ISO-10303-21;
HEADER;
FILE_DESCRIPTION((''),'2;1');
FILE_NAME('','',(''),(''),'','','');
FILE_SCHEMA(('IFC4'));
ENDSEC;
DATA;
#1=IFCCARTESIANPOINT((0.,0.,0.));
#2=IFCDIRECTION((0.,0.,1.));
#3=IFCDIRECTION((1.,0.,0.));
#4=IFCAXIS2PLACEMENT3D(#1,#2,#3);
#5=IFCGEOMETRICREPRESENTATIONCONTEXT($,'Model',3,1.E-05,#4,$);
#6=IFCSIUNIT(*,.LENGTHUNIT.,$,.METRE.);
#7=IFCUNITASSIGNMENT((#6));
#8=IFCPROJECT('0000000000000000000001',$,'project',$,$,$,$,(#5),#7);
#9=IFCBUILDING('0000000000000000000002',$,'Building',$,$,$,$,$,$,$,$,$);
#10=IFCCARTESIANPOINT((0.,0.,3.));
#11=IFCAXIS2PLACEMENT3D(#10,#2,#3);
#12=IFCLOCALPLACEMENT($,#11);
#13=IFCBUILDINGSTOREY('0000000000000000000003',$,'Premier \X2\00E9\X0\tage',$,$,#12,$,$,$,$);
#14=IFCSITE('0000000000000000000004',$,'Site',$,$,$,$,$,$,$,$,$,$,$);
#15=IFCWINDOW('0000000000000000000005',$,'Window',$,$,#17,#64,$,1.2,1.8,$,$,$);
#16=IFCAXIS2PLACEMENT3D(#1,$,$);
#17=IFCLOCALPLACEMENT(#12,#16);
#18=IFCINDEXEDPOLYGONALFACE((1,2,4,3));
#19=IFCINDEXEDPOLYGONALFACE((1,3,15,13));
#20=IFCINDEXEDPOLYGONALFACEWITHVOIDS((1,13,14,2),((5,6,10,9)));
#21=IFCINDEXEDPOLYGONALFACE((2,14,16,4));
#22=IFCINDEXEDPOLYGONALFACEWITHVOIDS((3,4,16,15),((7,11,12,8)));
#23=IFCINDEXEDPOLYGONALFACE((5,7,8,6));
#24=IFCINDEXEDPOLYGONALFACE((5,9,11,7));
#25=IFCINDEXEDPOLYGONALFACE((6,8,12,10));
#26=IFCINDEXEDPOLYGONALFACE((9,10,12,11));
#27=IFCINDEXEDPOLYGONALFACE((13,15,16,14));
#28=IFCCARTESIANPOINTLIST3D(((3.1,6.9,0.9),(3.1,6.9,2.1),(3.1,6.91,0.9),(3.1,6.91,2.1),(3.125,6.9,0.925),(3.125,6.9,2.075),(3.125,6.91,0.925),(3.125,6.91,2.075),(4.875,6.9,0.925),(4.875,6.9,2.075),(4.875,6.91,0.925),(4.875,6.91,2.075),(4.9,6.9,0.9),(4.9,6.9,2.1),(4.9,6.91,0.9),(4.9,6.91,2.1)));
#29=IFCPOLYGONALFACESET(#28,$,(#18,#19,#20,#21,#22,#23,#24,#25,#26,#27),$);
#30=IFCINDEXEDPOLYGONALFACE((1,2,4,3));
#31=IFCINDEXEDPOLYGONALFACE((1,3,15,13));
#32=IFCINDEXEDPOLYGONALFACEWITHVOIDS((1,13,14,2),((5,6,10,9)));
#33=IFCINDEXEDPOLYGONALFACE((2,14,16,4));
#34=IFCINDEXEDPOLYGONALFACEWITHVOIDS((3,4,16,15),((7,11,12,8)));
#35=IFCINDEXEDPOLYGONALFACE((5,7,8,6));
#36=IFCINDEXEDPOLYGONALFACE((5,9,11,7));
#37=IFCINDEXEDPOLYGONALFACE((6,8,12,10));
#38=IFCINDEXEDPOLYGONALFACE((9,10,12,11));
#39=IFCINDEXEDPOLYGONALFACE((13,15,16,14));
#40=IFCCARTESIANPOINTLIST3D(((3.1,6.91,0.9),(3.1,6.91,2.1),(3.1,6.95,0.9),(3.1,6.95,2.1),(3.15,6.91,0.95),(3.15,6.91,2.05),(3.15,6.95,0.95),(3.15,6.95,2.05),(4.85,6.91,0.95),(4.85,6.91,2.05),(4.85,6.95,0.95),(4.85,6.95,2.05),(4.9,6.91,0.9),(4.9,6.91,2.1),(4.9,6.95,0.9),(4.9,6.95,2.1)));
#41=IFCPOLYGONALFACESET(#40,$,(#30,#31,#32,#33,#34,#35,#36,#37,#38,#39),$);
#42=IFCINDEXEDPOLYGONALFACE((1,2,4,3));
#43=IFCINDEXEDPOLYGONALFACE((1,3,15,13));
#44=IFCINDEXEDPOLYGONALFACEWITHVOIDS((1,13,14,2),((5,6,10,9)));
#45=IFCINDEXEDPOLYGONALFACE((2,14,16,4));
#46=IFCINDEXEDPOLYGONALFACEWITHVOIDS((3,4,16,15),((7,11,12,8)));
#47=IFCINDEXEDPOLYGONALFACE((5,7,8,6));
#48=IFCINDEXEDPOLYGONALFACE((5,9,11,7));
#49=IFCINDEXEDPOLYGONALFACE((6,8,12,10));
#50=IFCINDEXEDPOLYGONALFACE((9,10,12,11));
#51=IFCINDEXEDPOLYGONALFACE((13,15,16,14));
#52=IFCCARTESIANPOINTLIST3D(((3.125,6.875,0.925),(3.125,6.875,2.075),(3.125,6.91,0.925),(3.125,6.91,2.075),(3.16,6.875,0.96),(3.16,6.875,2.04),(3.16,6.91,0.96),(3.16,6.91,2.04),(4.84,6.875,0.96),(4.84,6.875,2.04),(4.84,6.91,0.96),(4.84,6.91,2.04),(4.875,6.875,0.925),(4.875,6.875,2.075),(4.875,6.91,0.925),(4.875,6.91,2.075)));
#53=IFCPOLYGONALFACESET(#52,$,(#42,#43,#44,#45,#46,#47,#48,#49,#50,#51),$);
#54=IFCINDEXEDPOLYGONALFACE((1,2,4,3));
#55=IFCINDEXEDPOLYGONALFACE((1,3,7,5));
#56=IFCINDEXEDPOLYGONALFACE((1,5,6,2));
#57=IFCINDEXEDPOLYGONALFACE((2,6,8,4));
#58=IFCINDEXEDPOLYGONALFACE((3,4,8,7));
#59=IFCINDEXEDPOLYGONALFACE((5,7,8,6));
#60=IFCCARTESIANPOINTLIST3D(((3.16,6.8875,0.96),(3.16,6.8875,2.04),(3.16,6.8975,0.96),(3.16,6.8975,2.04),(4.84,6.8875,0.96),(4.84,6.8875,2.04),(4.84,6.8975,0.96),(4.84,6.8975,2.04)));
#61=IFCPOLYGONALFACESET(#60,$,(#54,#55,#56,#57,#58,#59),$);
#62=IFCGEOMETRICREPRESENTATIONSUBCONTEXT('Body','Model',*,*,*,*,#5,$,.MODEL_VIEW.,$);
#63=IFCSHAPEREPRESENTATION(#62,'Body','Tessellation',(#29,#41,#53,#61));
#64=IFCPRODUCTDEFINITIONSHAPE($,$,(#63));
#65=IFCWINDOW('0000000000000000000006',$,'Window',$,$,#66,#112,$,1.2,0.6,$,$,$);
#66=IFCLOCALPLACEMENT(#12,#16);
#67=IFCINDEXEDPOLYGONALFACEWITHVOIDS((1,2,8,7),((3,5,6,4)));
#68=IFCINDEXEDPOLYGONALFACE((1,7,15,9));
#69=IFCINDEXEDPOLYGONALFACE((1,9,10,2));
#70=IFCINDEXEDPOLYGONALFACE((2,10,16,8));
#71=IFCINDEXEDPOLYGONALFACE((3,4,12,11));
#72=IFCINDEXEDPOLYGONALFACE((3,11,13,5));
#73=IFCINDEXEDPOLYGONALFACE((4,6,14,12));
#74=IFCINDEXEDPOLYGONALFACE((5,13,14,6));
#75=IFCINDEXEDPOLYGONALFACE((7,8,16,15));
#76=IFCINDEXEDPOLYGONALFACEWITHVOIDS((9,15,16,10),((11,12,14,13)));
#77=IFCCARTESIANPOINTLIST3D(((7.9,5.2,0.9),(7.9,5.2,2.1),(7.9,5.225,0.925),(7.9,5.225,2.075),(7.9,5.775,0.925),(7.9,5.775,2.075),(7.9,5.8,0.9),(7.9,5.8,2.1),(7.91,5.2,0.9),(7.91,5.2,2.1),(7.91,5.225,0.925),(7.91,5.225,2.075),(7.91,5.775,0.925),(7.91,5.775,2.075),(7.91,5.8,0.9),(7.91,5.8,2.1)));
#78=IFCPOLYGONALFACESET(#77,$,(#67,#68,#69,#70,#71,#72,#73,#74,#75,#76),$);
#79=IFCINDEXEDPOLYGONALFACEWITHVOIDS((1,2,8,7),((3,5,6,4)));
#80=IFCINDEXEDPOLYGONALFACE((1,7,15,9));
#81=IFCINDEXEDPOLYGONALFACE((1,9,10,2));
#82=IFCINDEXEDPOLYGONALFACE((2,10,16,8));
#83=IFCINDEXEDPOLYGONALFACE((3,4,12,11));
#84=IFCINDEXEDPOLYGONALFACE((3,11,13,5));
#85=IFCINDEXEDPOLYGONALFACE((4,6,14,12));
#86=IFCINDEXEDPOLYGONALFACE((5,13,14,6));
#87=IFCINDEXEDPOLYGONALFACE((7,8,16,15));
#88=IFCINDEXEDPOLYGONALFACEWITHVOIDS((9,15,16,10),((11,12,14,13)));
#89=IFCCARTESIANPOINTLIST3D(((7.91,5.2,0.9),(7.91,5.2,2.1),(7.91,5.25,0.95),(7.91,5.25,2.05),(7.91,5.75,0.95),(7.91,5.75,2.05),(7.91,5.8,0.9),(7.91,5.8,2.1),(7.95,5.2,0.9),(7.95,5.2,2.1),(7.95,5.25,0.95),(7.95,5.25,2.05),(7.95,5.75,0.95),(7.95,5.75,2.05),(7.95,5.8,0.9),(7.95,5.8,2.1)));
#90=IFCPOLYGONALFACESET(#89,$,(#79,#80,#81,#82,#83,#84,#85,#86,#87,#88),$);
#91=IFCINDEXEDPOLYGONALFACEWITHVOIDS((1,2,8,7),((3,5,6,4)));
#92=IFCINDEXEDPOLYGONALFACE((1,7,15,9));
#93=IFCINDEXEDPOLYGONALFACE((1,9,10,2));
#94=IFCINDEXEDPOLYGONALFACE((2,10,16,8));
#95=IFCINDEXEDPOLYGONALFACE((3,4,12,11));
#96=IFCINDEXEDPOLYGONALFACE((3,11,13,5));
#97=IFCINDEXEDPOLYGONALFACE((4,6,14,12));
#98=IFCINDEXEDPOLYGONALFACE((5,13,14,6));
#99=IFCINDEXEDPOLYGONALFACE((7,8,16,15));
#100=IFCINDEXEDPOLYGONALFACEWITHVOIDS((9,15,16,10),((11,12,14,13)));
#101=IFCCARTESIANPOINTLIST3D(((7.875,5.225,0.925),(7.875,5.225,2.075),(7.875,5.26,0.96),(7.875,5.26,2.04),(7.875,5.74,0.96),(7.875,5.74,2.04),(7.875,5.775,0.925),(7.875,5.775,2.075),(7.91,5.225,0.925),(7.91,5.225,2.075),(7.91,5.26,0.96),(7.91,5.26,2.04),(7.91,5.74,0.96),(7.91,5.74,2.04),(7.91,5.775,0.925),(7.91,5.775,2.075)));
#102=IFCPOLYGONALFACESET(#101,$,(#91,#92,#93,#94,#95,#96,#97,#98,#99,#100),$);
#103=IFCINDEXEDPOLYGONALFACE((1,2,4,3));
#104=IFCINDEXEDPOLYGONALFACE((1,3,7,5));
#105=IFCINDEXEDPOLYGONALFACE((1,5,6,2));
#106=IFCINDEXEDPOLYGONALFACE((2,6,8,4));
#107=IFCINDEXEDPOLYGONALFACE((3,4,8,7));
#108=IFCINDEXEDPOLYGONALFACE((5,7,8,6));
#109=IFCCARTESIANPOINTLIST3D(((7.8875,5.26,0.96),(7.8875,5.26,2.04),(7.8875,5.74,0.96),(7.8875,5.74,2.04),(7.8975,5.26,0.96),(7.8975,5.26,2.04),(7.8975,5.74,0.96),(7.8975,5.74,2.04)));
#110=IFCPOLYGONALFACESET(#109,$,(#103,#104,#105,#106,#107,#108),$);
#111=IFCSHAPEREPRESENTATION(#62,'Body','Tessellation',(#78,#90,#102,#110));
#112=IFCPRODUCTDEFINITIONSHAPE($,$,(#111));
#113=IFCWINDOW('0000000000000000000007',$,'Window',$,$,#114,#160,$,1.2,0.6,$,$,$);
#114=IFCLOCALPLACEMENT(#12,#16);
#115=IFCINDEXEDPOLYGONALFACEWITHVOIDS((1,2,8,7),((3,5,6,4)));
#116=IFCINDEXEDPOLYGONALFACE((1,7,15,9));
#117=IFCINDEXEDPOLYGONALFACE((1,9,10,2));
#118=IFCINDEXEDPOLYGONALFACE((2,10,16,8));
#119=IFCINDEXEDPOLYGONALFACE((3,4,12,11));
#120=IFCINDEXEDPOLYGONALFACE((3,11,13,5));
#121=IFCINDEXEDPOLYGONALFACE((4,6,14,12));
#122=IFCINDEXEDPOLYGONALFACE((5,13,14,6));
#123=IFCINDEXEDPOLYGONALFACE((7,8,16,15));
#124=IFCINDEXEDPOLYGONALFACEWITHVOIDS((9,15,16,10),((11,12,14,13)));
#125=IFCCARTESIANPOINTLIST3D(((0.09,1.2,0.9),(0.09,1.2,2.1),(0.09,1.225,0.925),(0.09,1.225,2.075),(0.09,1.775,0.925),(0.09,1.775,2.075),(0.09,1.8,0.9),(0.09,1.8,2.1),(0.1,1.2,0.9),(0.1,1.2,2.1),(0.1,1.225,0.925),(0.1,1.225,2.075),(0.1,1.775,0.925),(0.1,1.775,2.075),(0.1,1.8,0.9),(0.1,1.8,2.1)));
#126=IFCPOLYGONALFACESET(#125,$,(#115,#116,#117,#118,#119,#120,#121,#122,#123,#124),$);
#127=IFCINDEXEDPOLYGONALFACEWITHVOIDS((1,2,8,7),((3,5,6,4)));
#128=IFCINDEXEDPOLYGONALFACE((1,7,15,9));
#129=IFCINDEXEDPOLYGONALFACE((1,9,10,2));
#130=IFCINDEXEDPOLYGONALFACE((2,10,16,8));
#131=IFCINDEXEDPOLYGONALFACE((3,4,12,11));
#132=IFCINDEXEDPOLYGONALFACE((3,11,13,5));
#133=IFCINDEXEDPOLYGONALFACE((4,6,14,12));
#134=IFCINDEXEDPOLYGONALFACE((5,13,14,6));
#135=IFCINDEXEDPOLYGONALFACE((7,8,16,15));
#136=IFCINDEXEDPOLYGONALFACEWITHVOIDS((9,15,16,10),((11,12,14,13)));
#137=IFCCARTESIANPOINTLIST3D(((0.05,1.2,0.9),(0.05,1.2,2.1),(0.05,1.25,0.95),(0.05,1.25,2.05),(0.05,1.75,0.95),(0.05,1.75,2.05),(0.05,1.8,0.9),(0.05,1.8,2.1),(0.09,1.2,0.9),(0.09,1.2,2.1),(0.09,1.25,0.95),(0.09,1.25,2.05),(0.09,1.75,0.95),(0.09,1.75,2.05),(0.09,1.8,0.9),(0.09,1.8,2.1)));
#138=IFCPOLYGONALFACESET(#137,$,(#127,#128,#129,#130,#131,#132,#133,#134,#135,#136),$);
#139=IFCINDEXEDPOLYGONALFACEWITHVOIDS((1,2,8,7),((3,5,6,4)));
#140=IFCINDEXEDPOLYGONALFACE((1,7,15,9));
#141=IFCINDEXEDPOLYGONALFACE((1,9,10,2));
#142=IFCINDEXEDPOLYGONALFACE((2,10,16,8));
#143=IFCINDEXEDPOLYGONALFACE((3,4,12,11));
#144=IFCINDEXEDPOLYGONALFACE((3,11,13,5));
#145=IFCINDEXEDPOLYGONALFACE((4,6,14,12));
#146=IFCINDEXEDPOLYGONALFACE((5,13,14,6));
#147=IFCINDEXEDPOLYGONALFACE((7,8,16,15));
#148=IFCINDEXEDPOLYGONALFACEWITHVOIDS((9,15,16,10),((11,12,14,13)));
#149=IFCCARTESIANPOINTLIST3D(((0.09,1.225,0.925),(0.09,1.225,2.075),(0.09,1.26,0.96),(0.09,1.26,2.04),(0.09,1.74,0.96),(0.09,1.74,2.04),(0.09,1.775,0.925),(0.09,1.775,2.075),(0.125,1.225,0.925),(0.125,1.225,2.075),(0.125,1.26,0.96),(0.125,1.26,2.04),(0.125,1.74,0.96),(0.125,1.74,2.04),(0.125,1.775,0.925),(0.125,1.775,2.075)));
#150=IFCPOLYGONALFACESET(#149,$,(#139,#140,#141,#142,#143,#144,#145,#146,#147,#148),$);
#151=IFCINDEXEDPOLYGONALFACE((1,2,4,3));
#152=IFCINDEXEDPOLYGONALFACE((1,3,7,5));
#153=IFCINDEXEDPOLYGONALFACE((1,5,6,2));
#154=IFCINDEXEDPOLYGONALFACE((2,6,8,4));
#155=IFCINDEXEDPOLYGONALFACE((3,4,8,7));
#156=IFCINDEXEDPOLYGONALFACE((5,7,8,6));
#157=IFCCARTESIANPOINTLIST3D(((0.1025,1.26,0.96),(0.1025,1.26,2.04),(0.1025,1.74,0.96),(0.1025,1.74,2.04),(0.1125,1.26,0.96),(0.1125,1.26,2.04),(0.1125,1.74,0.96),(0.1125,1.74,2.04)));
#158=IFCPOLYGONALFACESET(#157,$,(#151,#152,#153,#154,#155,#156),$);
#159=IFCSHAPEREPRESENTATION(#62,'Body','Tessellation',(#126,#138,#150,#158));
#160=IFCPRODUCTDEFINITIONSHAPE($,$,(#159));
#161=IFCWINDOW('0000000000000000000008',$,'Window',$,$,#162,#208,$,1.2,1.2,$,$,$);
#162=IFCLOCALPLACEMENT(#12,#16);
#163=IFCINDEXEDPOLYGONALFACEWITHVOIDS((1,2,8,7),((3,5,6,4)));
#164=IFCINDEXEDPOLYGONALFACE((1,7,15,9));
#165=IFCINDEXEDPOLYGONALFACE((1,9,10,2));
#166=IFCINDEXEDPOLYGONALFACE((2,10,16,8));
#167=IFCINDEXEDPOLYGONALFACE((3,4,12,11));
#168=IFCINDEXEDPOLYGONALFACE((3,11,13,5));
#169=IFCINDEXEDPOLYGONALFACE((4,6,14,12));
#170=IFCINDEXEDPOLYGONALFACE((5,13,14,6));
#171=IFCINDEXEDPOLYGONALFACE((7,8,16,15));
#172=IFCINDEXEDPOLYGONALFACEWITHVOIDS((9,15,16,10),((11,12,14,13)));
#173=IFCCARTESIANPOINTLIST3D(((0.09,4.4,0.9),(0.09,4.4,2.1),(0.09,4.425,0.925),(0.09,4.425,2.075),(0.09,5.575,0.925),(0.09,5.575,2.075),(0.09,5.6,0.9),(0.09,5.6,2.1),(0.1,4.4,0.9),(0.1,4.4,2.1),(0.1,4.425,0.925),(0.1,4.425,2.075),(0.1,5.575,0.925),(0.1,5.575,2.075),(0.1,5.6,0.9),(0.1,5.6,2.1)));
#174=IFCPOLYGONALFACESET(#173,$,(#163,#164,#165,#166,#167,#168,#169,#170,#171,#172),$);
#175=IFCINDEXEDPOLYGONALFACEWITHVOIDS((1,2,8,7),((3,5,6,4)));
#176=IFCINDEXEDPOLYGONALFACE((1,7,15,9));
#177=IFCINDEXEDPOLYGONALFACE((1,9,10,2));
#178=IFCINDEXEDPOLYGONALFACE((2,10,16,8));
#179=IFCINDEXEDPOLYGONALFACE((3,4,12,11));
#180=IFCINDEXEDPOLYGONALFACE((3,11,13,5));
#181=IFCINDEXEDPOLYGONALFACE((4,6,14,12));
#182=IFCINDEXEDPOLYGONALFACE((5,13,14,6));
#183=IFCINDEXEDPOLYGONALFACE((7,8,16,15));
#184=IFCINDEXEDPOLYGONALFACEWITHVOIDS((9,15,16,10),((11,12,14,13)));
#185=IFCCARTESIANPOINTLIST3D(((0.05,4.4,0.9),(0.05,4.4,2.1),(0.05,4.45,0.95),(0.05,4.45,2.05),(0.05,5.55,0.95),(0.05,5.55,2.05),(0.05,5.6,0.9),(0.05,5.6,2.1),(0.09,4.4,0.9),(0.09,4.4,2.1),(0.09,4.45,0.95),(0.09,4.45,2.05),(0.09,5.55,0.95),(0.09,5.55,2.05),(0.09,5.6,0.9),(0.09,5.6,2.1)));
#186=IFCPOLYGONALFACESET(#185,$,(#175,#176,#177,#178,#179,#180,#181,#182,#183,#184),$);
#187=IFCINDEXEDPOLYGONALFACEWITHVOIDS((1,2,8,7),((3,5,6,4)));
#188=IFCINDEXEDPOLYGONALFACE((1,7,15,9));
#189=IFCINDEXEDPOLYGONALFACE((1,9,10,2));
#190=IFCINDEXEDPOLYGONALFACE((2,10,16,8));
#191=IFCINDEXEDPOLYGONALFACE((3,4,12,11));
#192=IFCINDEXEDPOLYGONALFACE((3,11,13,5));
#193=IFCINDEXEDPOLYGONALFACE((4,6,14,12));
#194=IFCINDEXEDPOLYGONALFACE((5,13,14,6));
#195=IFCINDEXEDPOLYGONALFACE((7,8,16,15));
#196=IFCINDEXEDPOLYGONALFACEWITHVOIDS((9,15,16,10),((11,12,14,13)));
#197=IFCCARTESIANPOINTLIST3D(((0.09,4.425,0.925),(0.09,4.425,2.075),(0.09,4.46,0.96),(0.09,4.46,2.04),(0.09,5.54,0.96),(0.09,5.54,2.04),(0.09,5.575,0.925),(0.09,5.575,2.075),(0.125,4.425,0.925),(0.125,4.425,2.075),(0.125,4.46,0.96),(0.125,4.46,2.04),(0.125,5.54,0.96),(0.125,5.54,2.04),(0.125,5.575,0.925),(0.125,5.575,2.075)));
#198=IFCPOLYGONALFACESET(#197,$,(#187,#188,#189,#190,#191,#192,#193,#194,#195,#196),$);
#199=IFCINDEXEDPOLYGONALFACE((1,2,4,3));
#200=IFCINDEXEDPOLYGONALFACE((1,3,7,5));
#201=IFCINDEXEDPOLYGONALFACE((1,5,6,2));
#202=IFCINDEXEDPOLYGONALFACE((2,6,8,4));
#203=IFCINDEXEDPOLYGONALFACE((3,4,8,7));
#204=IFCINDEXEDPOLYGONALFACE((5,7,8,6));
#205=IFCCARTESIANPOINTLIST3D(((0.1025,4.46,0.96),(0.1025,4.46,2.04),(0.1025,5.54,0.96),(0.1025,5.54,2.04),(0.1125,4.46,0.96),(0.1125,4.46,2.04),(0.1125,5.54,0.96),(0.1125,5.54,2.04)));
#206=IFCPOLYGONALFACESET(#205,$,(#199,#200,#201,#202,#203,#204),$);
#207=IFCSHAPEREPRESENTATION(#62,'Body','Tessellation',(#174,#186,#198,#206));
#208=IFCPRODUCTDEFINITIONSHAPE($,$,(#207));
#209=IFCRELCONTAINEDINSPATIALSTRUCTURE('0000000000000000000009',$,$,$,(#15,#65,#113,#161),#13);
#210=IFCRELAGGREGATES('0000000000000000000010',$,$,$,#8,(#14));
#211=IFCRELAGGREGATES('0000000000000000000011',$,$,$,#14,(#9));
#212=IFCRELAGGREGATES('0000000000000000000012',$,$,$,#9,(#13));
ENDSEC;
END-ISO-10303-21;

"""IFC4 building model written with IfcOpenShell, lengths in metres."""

from ifc_helpers import new_model, si_unit, frame, origin_with_axes, place, context, subcontext, project, spatial, line, indexed_curve, outline, extrude, element, save


model = new_model("IFC4")

# Units and contexts
model_context = context("Model", 3, precision=1e-05, world=origin_with_axes())
body_context = subcontext(model_context, "Body", "Model", "MODEL_VIEW")
ifc_project = project(units=[si_unit("LENGTHUNIT", "METRE")], contexts=[model_context])

# Site, building, storey
site = spatial("IfcSite", under=ifc_project, Name="Site")
building = spatial("IfcBuilding", under=site, Name="Building")
storey_placement = place(None, frame((0.0, 0.0, 3.0), z_axis=(0.0, 0.0, 1.0), x_axis=(1.0, 0.0, 0.0)))
storey = spatial("IfcBuildingStorey", under=building, at=storey_placement, Name="Premier étage")

# Windows
window_1_placement = place(storey_placement, frame((4.9, 7.0, 0.9), z_axis=(0.0, 0.0, 1.0), x_axis=(-1.0, 0.0, 0.0)))
element("IfcWindow", 1, at=window_1_placement, inside=storey, Name="Window", OverallHeight=1.2, OverallWidth=1.8, context=body_context, shape_type="SweptSolid", body=[
    extrude(outline(indexed_curve([(0.0, 0.0), (1.8, 0.0), (1.8, 1.2), (0.0, 1.2)], segments=[line(1, 2, 3, 4, 1)]), holes=[indexed_curve([(0.025, 0.025), (1.775, 0.025), (1.775, 1.175), (0.025, 1.175)], segments=[line(1, 2, 3, 4, 1)])]), frame((0.0, 0.09, 0.0), z_axis=(0.0, -1.0, 0.0), x_axis=(1.0, 0.0, 0.0)), (0.0, 0.0, -1.0), 0.01),
    extrude(outline(indexed_curve([(0.0, 0.0), (1.8, 0.0), (1.8, 1.2), (0.0, 1.2)], segments=[line(1, 2, 3, 4, 1)]), holes=[indexed_curve([(0.05, 0.05), (1.75, 0.05), (1.75, 1.15), (0.05, 1.15)], segments=[line(1, 2, 3, 4, 1)])]), frame((0.0, 0.05, 0.0), z_axis=(0.0, -1.0, 0.0), x_axis=(1.0, 0.0, 0.0)), (0.0, 0.0, -1.0), 0.04),
    extrude(outline(indexed_curve([(0.0, 0.0), (1.75, 0.0), (1.75, 1.15), (0.0, 1.15)], segments=[line(1, 2, 3, 4, 1)]), holes=[indexed_curve([(0.035, 0.035), (1.715, 0.035), (1.715, 1.115), (0.035, 1.115)], segments=[line(1, 2, 3, 4, 1)])]), frame((0.025, 0.09, 0.025), z_axis=(0.0, -1.0, 0.0), x_axis=(1.0, 0.0, 0.0)), (0.0, 0.0, -1.0), 0.035),
    extrude(outline(indexed_curve([(0.035, 0.035), (1.715, 0.035), (1.715, 1.115), (0.035, 1.115)], segments=[line(1, 2, 3, 4, 1)])), frame((0.025, 0.1025, 0.025), z_axis=(0.0, -1.0, 0.0), x_axis=(1.0, 0.0, 0.0)), (0.0, 0.0, -1.0), 0.01),
])
for number, where, z_axis, x_axis, name in (
    (2, (8.0, 5.2, 0.9), (0.0, 0.0, 1.0), (0.0, 1.0, 0.0), "Window"),
    (3, (0.0, 1.8, 0.9), (0.0, 0.0, 1.0), (0.0, -1.0, 0.0), "Window"),
):
    element("IfcWindow", number, at=place(storey_placement, frame(where, z_axis=z_axis, x_axis=x_axis)), inside=storey, Name=name, OverallHeight=1.2, OverallWidth=0.6, context=body_context, shape_type="SweptSolid", body=[
        extrude(outline(indexed_curve([(0.0, 0.0), (0.6, 0.0), (0.6, 1.2), (0.0, 1.2)], segments=[line(1, 2, 3, 4, 1)]), holes=[indexed_curve([(0.025, 0.025), (0.575, 0.025), (0.575, 1.175), (0.025, 1.175)], segments=[line(1, 2, 3, 4, 1)])]), frame((0.0, 0.09, 0.0), z_axis=(0.0, -1.0, 0.0), x_axis=(1.0, 0.0, 0.0)), (0.0, 0.0, -1.0), 0.01),
        extrude(outline(indexed_curve([(0.0, 0.0), (0.6, 0.0), (0.6, 1.2), (0.0, 1.2)], segments=[line(1, 2, 3, 4, 1)]), holes=[indexed_curve([(0.05, 0.05), (0.55, 0.05), (0.55, 1.15), (0.05, 1.15)], segments=[line(1, 2, 3, 4, 1)])]), frame((0.0, 0.05, 0.0), z_axis=(0.0, -1.0, 0.0), x_axis=(1.0, 0.0, 0.0)), (0.0, 0.0, -1.0), 0.04),
        extrude(outline(indexed_curve([(0.0, 0.0), (0.55, 0.0), (0.55, 1.15), (0.0, 1.15)], segments=[line(1, 2, 3, 4, 1)]), holes=[indexed_curve([(0.035, 0.035), (0.515, 0.035), (0.515, 1.115), (0.035, 1.115)], segments=[line(1, 2, 3, 4, 1)])]), frame((0.025, 0.09, 0.025), z_axis=(0.0, -1.0, 0.0), x_axis=(1.0, 0.0, 0.0)), (0.0, 0.0, -1.0), 0.035),
        extrude(outline(indexed_curve([(0.035, 0.035), (0.515, 0.035), (0.515, 1.115), (0.035, 1.115)], segments=[line(1, 2, 3, 4, 1)])), frame((0.025, 0.1025, 0.025), z_axis=(0.0, -1.0, 0.0), x_axis=(1.0, 0.0, 0.0)), (0.0, 0.0, -1.0), 0.01),
    ])
window_2_placement = place(storey_placement, frame((0.0, 5.6, 0.9), z_axis=(0.0, 0.0, 1.0), x_axis=(0.0, -1.0, 0.0)))
element("IfcWindow", 4, at=window_2_placement, inside=storey, Name="Window", OverallHeight=1.2, OverallWidth=1.2, context=body_context, shape_type="SweptSolid", body=[
    extrude(outline(indexed_curve([(0.0, 0.0), (1.2, 0.0), (1.2, 1.2), (0.0, 1.2)], segments=[line(1, 2, 3, 4, 1)]), holes=[indexed_curve([(0.025, 0.025), (1.175, 0.025), (1.175, 1.175), (0.025, 1.175)], segments=[line(1, 2, 3, 4, 1)])]), frame((0.0, 0.09, 0.0), z_axis=(0.0, -1.0, 0.0), x_axis=(1.0, 0.0, 0.0)), (0.0, 0.0, -1.0), 0.01),
    extrude(outline(indexed_curve([(0.0, 0.0), (1.2, 0.0), (1.2, 1.2), (0.0, 1.2)], segments=[line(1, 2, 3, 4, 1)]), holes=[indexed_curve([(0.05, 0.05), (1.15, 0.05), (1.15, 1.15), (0.05, 1.15)], segments=[line(1, 2, 3, 4, 1)])]), frame((0.0, 0.05, 0.0), z_axis=(0.0, -1.0, 0.0), x_axis=(1.0, 0.0, 0.0)), (0.0, 0.0, -1.0), 0.04),
    extrude(outline(indexed_curve([(0.0, 0.0), (1.15, 0.0), (1.15, 1.15), (0.0, 1.15)], segments=[line(1, 2, 3, 4, 1)]), holes=[indexed_curve([(0.035, 0.035), (1.115, 0.035), (1.115, 1.115), (0.035, 1.115)], segments=[line(1, 2, 3, 4, 1)])]), frame((0.025, 0.09, 0.025), z_axis=(0.0, -1.0, 0.0), x_axis=(1.0, 0.0, 0.0)), (0.0, 0.0, -1.0), 0.035),
    extrude(outline(indexed_curve([(0.035, 0.035), (1.115, 0.035), (1.115, 1.115), (0.035, 1.115)], segments=[line(1, 2, 3, 4, 1)])), frame((0.025, 0.1025, 0.025), z_axis=(0.0, -1.0, 0.0), x_axis=(1.0, 0.0, 0.0)), (0.0, 0.0, -1.0), 0.01),
])

save(model, "model.ifc")
